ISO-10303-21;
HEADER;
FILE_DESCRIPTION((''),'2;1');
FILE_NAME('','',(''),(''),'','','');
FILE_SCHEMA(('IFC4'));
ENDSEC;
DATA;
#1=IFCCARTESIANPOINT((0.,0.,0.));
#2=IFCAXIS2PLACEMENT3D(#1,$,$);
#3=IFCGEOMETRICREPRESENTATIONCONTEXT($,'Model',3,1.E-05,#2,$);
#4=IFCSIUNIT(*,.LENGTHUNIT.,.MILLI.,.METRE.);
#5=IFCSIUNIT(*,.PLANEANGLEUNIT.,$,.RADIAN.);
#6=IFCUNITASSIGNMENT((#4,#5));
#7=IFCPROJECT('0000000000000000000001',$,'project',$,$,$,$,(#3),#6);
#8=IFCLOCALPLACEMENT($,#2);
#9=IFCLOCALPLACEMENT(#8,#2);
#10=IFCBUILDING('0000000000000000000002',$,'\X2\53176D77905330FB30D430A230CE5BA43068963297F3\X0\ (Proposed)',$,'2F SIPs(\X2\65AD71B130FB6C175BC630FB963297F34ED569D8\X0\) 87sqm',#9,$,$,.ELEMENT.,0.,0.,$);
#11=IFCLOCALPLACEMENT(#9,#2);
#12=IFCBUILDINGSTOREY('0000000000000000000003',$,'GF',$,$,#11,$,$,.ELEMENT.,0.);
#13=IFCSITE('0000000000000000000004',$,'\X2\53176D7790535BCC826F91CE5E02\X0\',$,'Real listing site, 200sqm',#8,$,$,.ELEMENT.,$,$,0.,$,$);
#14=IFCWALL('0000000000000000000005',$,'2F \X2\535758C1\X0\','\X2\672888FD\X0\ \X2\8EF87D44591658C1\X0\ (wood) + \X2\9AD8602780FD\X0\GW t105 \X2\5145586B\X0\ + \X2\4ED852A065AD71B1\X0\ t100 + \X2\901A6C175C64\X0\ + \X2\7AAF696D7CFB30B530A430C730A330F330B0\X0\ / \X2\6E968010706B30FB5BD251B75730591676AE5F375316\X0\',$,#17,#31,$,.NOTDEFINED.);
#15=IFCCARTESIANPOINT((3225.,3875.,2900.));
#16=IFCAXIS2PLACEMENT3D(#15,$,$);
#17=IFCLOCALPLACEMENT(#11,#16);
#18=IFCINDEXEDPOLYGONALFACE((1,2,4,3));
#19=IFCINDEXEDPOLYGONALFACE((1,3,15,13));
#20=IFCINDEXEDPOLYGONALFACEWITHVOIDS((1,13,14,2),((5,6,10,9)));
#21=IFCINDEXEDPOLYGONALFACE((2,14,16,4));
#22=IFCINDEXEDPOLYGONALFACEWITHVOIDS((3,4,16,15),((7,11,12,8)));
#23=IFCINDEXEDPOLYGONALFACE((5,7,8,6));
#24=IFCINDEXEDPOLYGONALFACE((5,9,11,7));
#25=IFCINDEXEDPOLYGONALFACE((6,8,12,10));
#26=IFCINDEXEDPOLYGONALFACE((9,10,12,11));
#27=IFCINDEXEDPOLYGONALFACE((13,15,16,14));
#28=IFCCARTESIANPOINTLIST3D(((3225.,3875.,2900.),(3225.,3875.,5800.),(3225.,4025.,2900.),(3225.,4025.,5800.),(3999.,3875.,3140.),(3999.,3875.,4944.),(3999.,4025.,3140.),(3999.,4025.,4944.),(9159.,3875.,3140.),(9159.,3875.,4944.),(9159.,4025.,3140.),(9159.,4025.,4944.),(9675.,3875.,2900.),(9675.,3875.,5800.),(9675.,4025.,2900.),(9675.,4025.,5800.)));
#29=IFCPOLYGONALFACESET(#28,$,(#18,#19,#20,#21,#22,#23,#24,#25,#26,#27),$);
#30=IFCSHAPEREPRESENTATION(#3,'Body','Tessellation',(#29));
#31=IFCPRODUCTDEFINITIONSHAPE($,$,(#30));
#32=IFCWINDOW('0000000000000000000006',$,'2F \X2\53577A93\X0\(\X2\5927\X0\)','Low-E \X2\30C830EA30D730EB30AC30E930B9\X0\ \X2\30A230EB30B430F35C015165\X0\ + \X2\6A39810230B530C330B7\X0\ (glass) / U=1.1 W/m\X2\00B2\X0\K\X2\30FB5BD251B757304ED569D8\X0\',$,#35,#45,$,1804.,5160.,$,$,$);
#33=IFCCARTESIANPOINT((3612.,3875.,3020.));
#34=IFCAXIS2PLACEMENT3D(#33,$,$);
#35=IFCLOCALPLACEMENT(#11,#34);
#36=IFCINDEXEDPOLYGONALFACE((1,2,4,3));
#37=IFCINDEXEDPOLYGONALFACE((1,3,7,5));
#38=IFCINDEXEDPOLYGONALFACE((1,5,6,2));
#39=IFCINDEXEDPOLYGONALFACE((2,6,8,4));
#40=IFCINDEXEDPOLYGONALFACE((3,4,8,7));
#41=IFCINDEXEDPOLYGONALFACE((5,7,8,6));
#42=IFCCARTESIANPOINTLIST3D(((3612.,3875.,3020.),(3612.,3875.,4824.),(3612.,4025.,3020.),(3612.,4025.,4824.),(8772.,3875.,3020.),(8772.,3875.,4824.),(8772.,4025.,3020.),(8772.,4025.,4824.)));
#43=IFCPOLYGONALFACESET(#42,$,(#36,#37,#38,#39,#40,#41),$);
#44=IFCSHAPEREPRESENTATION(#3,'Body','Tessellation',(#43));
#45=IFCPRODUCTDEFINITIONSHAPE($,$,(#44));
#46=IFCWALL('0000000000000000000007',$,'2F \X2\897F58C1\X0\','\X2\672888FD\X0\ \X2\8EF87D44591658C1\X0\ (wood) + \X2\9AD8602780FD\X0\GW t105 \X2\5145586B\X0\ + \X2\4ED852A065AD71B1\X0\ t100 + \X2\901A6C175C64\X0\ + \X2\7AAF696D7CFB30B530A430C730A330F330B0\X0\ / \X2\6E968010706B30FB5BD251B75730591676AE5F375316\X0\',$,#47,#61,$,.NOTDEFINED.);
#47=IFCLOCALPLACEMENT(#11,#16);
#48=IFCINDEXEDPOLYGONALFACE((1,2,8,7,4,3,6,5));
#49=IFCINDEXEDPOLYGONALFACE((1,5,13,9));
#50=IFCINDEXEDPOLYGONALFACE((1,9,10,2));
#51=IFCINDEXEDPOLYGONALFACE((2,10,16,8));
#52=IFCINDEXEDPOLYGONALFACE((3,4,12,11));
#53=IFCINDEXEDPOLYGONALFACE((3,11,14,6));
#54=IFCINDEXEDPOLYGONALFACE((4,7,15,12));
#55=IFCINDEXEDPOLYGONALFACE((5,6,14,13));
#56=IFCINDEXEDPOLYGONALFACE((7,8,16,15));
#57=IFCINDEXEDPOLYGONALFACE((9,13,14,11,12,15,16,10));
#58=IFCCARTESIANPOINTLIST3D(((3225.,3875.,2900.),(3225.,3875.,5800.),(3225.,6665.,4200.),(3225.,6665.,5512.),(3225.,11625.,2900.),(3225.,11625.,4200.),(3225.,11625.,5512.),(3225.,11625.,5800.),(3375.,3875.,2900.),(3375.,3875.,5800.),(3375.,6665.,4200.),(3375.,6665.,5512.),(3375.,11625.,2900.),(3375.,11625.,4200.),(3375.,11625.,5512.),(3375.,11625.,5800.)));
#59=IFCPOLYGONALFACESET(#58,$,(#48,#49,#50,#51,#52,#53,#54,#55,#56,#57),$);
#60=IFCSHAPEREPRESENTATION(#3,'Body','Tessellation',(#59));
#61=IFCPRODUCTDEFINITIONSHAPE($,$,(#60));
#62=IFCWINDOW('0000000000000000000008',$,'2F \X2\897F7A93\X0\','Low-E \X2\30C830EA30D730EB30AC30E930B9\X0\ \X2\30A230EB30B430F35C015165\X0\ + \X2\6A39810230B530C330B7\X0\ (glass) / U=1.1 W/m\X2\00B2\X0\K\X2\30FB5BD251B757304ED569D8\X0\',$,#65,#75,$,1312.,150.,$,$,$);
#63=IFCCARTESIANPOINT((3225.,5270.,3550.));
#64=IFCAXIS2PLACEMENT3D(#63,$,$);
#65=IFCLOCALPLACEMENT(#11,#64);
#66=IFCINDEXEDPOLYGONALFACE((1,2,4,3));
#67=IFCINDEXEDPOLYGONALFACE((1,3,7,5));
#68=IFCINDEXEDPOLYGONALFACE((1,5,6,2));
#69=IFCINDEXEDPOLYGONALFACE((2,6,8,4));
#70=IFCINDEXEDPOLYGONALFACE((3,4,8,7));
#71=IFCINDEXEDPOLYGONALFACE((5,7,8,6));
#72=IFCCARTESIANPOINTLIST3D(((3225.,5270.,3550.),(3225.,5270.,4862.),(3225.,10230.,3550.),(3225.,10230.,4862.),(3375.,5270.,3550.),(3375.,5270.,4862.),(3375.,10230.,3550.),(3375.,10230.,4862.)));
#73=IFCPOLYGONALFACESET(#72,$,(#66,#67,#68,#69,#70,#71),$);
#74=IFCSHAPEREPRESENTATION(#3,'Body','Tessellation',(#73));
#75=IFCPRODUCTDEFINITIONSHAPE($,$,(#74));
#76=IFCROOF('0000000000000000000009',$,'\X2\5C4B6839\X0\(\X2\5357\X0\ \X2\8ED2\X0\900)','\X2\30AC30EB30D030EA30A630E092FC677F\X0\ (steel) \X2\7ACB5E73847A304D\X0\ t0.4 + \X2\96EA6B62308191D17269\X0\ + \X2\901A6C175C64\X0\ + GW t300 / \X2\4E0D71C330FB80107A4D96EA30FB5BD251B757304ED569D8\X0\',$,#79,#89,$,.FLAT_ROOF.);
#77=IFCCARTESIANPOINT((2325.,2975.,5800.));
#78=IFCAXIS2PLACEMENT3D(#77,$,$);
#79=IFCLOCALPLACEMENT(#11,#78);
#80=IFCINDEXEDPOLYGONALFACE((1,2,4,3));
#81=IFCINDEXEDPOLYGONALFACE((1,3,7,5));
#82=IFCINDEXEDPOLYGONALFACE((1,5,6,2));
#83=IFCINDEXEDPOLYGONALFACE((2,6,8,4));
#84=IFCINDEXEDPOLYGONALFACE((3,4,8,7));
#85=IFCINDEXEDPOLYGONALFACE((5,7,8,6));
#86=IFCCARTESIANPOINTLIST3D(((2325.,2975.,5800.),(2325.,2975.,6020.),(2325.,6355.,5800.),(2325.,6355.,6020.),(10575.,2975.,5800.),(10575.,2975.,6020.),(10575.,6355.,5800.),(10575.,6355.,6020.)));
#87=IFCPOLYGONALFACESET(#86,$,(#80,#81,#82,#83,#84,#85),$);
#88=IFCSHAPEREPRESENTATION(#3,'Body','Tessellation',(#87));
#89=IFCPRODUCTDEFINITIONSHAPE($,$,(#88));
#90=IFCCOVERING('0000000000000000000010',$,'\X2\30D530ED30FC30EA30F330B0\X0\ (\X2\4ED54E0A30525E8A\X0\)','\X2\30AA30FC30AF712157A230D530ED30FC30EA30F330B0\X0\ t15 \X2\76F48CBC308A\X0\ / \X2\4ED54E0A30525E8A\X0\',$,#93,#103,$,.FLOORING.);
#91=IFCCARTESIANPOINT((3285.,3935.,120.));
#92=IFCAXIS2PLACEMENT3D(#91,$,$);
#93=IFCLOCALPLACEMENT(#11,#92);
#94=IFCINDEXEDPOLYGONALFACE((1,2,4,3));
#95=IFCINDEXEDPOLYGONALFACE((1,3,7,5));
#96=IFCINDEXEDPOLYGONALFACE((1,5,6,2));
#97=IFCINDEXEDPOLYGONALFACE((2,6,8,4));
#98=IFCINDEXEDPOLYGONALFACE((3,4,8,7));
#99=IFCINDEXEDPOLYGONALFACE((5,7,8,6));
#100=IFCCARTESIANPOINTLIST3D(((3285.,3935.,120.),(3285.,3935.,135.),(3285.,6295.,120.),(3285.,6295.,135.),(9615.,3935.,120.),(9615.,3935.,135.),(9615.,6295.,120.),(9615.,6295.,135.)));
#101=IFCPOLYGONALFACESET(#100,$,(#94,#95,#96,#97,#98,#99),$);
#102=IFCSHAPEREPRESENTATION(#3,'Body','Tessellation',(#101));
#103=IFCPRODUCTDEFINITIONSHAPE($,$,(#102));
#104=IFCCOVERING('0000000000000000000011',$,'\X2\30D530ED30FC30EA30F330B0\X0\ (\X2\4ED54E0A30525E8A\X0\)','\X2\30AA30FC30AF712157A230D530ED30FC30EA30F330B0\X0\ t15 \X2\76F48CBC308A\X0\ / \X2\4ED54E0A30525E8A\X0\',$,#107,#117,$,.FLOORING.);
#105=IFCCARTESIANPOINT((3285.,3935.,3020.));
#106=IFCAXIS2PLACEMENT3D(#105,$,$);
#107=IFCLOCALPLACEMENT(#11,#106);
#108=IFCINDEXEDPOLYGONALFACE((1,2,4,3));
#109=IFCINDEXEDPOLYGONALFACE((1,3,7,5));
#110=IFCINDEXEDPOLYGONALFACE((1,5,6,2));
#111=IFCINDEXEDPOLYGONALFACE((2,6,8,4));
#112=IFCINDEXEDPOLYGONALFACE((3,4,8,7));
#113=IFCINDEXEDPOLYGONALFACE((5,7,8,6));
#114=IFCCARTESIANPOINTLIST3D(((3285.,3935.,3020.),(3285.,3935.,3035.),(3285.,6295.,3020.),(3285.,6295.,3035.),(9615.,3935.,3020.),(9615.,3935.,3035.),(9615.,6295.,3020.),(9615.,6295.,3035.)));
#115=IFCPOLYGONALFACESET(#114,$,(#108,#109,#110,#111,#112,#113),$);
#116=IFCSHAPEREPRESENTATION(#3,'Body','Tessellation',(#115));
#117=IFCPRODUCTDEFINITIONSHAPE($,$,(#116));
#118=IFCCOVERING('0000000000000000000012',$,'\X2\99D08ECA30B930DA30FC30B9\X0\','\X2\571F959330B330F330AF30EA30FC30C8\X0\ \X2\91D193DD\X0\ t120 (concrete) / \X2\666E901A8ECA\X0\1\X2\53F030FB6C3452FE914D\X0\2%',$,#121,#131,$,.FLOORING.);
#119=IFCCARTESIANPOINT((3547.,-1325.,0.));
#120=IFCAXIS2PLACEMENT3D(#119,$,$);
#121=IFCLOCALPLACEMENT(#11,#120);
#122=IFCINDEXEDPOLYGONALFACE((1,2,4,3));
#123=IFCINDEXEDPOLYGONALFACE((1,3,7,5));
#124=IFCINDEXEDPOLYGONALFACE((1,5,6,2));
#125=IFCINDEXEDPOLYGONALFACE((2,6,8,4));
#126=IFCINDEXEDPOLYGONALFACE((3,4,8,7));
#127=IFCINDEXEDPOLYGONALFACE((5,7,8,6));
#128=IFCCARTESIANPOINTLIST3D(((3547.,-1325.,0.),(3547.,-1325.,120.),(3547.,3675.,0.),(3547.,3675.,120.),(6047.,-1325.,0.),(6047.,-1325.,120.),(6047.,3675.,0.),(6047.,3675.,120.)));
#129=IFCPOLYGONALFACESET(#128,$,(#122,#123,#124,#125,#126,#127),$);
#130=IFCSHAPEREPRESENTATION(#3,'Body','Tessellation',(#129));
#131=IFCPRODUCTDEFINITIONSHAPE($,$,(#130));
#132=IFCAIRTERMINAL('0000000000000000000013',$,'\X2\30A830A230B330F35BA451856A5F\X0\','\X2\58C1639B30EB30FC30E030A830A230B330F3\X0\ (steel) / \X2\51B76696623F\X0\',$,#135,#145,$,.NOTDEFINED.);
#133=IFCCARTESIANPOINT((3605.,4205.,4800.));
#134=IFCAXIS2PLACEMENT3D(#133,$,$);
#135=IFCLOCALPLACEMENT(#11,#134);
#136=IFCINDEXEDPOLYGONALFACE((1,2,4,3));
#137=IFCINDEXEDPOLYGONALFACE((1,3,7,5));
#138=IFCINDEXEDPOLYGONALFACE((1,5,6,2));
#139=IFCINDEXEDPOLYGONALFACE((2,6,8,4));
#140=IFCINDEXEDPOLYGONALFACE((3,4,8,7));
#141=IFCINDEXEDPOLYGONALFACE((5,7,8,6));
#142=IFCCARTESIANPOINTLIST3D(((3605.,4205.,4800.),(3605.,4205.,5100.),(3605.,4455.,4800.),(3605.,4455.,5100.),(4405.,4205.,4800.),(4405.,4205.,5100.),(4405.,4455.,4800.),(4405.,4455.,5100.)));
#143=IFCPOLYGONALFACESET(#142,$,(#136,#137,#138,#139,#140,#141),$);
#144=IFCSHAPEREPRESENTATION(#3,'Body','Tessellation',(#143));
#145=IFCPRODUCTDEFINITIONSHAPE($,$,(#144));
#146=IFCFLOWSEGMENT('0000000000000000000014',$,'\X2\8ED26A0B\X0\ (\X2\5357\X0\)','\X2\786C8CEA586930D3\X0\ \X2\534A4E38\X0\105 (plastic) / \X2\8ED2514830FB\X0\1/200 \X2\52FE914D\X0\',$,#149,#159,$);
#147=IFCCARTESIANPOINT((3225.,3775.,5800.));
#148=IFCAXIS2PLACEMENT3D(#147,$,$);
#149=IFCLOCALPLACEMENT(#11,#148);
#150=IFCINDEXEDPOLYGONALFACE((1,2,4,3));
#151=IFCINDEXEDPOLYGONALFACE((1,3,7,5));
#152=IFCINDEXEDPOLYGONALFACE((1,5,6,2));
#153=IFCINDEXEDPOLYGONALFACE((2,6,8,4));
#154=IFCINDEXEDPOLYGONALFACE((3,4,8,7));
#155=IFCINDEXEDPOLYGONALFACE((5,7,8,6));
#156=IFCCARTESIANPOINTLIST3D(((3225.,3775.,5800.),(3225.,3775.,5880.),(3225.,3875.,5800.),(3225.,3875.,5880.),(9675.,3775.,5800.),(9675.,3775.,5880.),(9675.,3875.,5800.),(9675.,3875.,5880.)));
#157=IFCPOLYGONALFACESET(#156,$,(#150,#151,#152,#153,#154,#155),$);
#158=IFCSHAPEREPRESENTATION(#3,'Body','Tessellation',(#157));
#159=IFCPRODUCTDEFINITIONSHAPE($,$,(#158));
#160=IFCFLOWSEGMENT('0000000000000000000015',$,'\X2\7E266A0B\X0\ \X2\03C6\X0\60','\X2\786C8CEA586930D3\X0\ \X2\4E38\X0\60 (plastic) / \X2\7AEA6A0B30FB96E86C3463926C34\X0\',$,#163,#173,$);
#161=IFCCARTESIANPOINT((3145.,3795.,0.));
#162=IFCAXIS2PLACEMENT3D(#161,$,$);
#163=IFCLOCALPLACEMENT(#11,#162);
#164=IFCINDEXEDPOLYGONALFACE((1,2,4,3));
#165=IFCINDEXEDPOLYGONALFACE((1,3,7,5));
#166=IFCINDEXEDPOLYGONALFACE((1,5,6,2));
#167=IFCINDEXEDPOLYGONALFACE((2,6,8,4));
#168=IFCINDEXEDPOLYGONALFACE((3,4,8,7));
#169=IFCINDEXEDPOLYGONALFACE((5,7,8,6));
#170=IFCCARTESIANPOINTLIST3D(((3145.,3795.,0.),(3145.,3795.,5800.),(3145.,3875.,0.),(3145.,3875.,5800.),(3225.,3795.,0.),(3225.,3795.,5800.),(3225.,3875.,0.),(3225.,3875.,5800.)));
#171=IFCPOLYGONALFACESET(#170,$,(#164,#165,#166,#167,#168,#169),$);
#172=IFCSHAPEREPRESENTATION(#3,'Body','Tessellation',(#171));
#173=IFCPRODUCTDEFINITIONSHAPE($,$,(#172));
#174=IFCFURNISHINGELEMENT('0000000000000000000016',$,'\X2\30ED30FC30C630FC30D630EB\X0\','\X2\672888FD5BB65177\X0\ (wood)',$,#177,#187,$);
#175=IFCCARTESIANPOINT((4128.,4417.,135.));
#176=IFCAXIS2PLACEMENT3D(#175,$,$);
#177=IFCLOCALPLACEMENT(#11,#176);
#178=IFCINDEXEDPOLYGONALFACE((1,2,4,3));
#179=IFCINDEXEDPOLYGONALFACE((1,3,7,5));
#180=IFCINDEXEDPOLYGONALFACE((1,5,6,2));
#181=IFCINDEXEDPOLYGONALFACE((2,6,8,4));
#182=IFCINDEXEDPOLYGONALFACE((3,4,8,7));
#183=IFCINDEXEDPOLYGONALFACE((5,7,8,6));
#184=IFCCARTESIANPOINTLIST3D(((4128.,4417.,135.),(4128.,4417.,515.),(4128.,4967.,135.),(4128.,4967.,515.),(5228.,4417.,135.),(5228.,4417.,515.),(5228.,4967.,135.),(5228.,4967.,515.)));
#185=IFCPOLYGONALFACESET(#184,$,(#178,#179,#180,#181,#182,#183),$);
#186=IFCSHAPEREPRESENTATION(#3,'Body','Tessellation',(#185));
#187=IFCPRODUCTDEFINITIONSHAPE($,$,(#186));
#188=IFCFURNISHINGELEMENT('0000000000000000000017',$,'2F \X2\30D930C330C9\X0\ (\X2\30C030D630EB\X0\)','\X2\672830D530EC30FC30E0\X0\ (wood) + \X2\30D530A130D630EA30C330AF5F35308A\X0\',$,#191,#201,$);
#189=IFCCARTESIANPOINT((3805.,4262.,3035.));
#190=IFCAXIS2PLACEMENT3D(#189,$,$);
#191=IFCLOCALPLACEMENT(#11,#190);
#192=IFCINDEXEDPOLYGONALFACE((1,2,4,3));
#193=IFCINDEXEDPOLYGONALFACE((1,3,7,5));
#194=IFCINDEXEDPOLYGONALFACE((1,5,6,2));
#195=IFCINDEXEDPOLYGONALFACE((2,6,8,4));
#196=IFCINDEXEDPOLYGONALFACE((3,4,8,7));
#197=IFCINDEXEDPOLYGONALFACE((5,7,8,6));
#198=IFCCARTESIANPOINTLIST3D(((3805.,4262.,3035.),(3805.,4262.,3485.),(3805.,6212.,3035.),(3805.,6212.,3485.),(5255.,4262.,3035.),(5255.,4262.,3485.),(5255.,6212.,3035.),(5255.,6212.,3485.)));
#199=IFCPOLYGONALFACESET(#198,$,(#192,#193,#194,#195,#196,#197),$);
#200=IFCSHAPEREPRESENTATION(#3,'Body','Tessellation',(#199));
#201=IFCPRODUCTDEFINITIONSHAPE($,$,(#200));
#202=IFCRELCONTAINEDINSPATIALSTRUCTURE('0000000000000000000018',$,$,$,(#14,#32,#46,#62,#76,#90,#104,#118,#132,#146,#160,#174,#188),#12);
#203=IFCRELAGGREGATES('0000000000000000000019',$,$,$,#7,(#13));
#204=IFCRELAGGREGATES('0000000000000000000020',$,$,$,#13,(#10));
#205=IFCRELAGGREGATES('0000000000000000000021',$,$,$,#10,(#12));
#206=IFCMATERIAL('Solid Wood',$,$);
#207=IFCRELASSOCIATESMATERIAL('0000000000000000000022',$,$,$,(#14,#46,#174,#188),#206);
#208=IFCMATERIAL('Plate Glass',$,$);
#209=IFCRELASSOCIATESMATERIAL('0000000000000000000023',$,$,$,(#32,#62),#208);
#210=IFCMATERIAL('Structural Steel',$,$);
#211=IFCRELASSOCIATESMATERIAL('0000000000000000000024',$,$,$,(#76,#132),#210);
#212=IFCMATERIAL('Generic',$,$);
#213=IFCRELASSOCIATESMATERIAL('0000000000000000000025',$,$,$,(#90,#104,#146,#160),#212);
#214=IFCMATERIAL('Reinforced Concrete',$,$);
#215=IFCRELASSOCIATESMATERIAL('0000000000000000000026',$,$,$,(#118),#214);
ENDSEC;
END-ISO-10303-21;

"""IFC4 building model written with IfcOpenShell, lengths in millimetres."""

from ifc_helpers import new_model, si_unit, frame, frame_2d, origin, place, context, project, spatial, rectangle, extrude, material, element, fill, save


model = new_model("IFC4")

# Units and contexts
model_context = context("Model", 3, precision=1e-05, world=origin())
ifc_project = project(units=[si_unit("LENGTHUNIT", "METRE", prefix="MILLI"), si_unit("PLANEANGLEUNIT", "RADIAN")], contexts=[model_context])

# Site, building, storey
site_placement = place(None, origin())
site = spatial("IfcSite", under=ifc_project, at=site_placement, Name="北海道富良野市", ObjectType="Real listing site, 200sqm", CompositionType="ELEMENT", RefElevation=0.0)
building_placement = place(site_placement, origin())
building = spatial("IfcBuilding", under=site, at=building_placement, Name="北海道・ピアノ室と防音 (Proposed)", ObjectType="2F SIPs(断熱・気密・防音仕様) 87sqm", CompositionType="ELEMENT", ElevationOfRefHeight=0.0, ElevationOfTerrain=0.0)
storey_placement = place(building_placement, origin())
storey = spatial("IfcBuildingStorey", under=building, at=storey_placement, Name="GF", CompositionType="ELEMENT", Elevation=0.0)

# Shared definitions
ifc_material_1 = material(Name="Solid Wood")

# Shared definitions
ifc_material_2 = material(Name="Reinforced Concrete")

# Shared definitions
ifc_material_3 = material(Name="Plate Glass")

# Walls, openings, windows
wall_1_placement = place(storey_placement, frame((3225.0, 3875.0, 2900.0)))
wall_1 = element("IfcWall", 1, at=wall_1_placement, inside=storey, material=ifc_material_1, Name="2F 南壁", Description="木製 軸組外壁 (wood) + 高性能GW t105 充填 + 付加断熱 t100 + 通気層 + 窯業系サイディング / 準耐火・寒冷地外皮強化", PredefinedType="NOTDEFINED", context=model_context, shape_type="SweptSolid", body=[
    extrude(rectangle(XDim=6450.0, YDim=150.0, at=frame_2d((3225.0, 75.0))), frame((3225.0, 3875.0, 2900.0)), (0.0, 0.0, 1.0), 2900.0),
])
opening_1_placement = place(storey_placement, frame((3612.0, 3875.0, 3020.0)))
opening_1 = element("IfcOpeningElement", 2, at=opening_1_placement, cuts=wall_1, PredefinedType="NOTDEFINED", context=model_context, shape_type="SweptSolid", body=[
    extrude(rectangle(XDim=5160.0, YDim=150.0, at=frame_2d((2580.0, 75.0))), frame((3612.0, 3875.0, 3020.0)), (0.0, 0.0, 1.0), 1804.0),
])
window_1_placement = place(storey_placement, frame((3612.0, 3875.0, 3020.0)))
window_1 = element("IfcWindow", 3, at=window_1_placement, inside=storey, material=ifc_material_3, Name="2F 南窓(大)", Description="Low-E トリプルガラス アルゴン封入 + 樹脂サッシ (glass) / U=1.1 W/m²K・寒冷地仕様", OverallHeight=1804.0, OverallWidth=5160.0, context=model_context, shape_type="SweptSolid", body=[
    extrude(rectangle(XDim=5160.0, YDim=150.0, at=frame_2d((2580.0, 75.0))), frame((3612.0, 3875.0, 3020.0)), (0.0, 0.0, 1.0), 1804.0),
])
fill(opening_1, window_1)
wall_2_placement = place(storey_placement, frame((3225.0, 3875.0, 2900.0)))
wall_2 = element("IfcWall", 4, at=wall_2_placement, inside=storey, material=ifc_material_1, Name="2F 西壁", Description="木製 軸組外壁 (wood) + 高性能GW t105 充填 + 付加断熱 t100 + 通気層 + 窯業系サイディング / 準耐火・寒冷地外皮強化", PredefinedType="NOTDEFINED", context=model_context, shape_type="SweptSolid", body=[
    extrude(rectangle(XDim=150.0, YDim=7750.0, at=frame_2d((75.0, 3875.0))), frame((3225.0, 3875.0, 2900.0)), (0.0, 0.0, 1.0), 2900.0),
])
opening_2_placement = place(storey_placement, frame((3225.0, 5270.0, 3550.0)))
opening_2 = element("IfcOpeningElement", 5, at=opening_2_placement, cuts=wall_2, PredefinedType="NOTDEFINED", context=model_context, shape_type="SweptSolid", body=[
    extrude(rectangle(XDim=150.0, YDim=4960.0, at=frame_2d((75.0, 2480.0))), frame((3225.0, 5270.0, 3550.0)), (0.0, 0.0, 1.0), 1312.0),
])
window_2_placement = place(storey_placement, frame((3225.0, 5270.0, 3550.0)))
window_2 = element("IfcWindow", 6, at=window_2_placement, inside=storey, material=ifc_material_3, Name="2F 西窓", Description="Low-E トリプルガラス アルゴン封入 + 樹脂サッシ (glass) / U=1.1 W/m²K・寒冷地仕様", OverallHeight=1312.0, OverallWidth=150.0, context=model_context, shape_type="SweptSolid", body=[
    extrude(rectangle(XDim=150.0, YDim=4960.0, at=frame_2d((75.0, 2480.0))), frame((3225.0, 5270.0, 3550.0)), (0.0, 0.0, 1.0), 1312.0),
])
fill(opening_2, window_2)

# Roof
ifc_material_4 = material(Name="Structural Steel")
for number, where, name in (
    (7, (2325.0, 2975.0, 5800.0), "屋根(南 軒900)"),
):
    element("IfcRoof", number, at=place(storey_placement, frame(where)), inside=storey, material=ifc_material_4, Name=name, Description="ガルバリウム鋼板 (steel) 立平葺き t0.4 + 雪止め金物 + 通気層 + GW t300 / 不燃・耐積雪・寒冷地仕様", PredefinedType="FLAT_ROOF", context=model_context, shape_type="SweptSolid", body=[
        extrude(rectangle(XDim=8250.0, YDim=3380.0, at=frame_2d((4125.0, 1690.0))), frame((2325.0, 2975.0, 5800.0)), (0.0, 0.0, 1.0), 220.0),
    ])

# Coverings
ifc_material_5 = material(Name="Generic")
covering_1_placement = place(storey_placement, frame((3285.0, 3935.0, 120.0)))
element("IfcCovering", 8, at=covering_1_placement, inside=storey, material=ifc_material_5, Name="フローリング (仕上げ床)", Description="オーク無垢フローリング t15 直貼り / 仕上げ床", PredefinedType="FLOORING", context=model_context, shape_type="SweptSolid", body=[
    extrude(rectangle(XDim=6330.0, YDim=2360.0, at=frame_2d((3165.0, 1180.0))), frame((3285.0, 3935.0, 120.0)), (0.0, 0.0, 1.0), 15.0),
])
covering_2_placement = place(storey_placement, frame((3285.0, 3935.0, 3020.0)))
element("IfcCovering", 9, at=covering_2_placement, inside=storey, material=ifc_material_5, Name="フローリング (仕上げ床)", Description="オーク無垢フローリング t15 直貼り / 仕上げ床", PredefinedType="FLOORING", context=model_context, shape_type="SweptSolid", body=[
    extrude(rectangle(XDim=6330.0, YDim=2360.0, at=frame_2d((3165.0, 1180.0))), frame((3285.0, 3935.0, 3020.0)), (0.0, 0.0, 1.0), 15.0),
])
covering_3_placement = place(storey_placement, frame((3547.0, -1325.0, 0.0)))
element("IfcCovering", 10, at=covering_3_placement, inside=storey, material=ifc_material_2, Name="駐車スペース", Description="土間コンクリート 金鏝 t120 (concrete) / 普通車1台・水勾配2%", PredefinedType="FLOORING", context=model_context, shape_type="SweptSolid", body=[
    extrude(rectangle(XDim=2500.0, YDim=5000.0, at=frame_2d((1250.0, 2500.0))), frame((3547.0, -1325.0, 0.0)), (0.0, 0.0, 1.0), 120.0),
])

# Air terminal
air_terminal_placement = place(storey_placement, frame((3605.0, 4205.0, 4800.0)))
element("IfcAirTerminal", 11, at=air_terminal_placement, inside=storey, material=ifc_material_4, Name="エアコン室内機", Description="壁掛ルームエアコン (steel) / 冷暖房", PredefinedType="NOTDEFINED", context=model_context, shape_type="SweptSolid", body=[
    extrude(rectangle(XDim=800.0, YDim=250.0, at=frame_2d((400.0, 125.0))), frame((3605.0, 4205.0, 4800.0)), (0.0, 0.0, 1.0), 300.0),
])

# Flow segments
flow_segment_1_placement = place(storey_placement, frame((3225.0, 3775.0, 5800.0)))
element("IfcFlowSegment", 12, at=flow_segment_1_placement, inside=storey, material=ifc_material_5, Name="軒樋 (南)", Description="硬質塩ビ 半丸105 (plastic) / 軒先・1/200 勾配", context=model_context, shape_type="SweptSolid", body=[
    extrude(rectangle(XDim=6450.0, YDim=100.0, at=frame_2d((3225.0, 50.0))), frame((3225.0, 3775.0, 5800.0)), (0.0, 0.0, 1.0), 80.0),
])
flow_segment_2_placement = place(storey_placement, frame((3145.0, 3795.0, 0.0)))
element("IfcFlowSegment", 13, at=flow_segment_2_placement, inside=storey, material=ifc_material_5, Name="縦樋 φ60", Description="硬質塩ビ 丸60 (plastic) / 竪樋・雨水排水", context=model_context, shape_type="SweptSolid", body=[
    extrude(rectangle(XDim=80.0, YDim=80.0, at=frame_2d((40.0, 40.0))), frame((3145.0, 3795.0, 0.0)), (0.0, 0.0, 1.0), 5800.0),
])

# Furnishing elements
furnishing_1_placement = place(storey_placement, frame((4128.0, 4417.0, 135.0)))
element("IfcFurnishingElement", 14, at=furnishing_1_placement, inside=storey, material=ifc_material_1, Name="ローテーブル", Description="木製家具 (wood)", context=model_context, shape_type="SweptSolid", body=[
    extrude(rectangle(XDim=1100.0, YDim=550.0, at=frame_2d((550.0, 275.0))), frame((4128.0, 4417.0, 135.0)), (0.0, 0.0, 1.0), 380.0),
])
furnishing_2_placement = place(storey_placement, frame((3805.0, 4262.0, 3035.0)))
element("IfcFurnishingElement", 15, at=furnishing_2_placement, inside=storey, material=ifc_material_1, Name="2F ベッド (ダブル)", Description="木フレーム (wood) + ファブリック張り", context=model_context, shape_type="SweptSolid", body=[
    extrude(rectangle(XDim=1450.0, YDim=1950.0, at=frame_2d((725.0, 975.0))), frame((3805.0, 4262.0, 3035.0)), (0.0, 0.0, 1.0), 450.0),
])

save(model, "model.ifc")
